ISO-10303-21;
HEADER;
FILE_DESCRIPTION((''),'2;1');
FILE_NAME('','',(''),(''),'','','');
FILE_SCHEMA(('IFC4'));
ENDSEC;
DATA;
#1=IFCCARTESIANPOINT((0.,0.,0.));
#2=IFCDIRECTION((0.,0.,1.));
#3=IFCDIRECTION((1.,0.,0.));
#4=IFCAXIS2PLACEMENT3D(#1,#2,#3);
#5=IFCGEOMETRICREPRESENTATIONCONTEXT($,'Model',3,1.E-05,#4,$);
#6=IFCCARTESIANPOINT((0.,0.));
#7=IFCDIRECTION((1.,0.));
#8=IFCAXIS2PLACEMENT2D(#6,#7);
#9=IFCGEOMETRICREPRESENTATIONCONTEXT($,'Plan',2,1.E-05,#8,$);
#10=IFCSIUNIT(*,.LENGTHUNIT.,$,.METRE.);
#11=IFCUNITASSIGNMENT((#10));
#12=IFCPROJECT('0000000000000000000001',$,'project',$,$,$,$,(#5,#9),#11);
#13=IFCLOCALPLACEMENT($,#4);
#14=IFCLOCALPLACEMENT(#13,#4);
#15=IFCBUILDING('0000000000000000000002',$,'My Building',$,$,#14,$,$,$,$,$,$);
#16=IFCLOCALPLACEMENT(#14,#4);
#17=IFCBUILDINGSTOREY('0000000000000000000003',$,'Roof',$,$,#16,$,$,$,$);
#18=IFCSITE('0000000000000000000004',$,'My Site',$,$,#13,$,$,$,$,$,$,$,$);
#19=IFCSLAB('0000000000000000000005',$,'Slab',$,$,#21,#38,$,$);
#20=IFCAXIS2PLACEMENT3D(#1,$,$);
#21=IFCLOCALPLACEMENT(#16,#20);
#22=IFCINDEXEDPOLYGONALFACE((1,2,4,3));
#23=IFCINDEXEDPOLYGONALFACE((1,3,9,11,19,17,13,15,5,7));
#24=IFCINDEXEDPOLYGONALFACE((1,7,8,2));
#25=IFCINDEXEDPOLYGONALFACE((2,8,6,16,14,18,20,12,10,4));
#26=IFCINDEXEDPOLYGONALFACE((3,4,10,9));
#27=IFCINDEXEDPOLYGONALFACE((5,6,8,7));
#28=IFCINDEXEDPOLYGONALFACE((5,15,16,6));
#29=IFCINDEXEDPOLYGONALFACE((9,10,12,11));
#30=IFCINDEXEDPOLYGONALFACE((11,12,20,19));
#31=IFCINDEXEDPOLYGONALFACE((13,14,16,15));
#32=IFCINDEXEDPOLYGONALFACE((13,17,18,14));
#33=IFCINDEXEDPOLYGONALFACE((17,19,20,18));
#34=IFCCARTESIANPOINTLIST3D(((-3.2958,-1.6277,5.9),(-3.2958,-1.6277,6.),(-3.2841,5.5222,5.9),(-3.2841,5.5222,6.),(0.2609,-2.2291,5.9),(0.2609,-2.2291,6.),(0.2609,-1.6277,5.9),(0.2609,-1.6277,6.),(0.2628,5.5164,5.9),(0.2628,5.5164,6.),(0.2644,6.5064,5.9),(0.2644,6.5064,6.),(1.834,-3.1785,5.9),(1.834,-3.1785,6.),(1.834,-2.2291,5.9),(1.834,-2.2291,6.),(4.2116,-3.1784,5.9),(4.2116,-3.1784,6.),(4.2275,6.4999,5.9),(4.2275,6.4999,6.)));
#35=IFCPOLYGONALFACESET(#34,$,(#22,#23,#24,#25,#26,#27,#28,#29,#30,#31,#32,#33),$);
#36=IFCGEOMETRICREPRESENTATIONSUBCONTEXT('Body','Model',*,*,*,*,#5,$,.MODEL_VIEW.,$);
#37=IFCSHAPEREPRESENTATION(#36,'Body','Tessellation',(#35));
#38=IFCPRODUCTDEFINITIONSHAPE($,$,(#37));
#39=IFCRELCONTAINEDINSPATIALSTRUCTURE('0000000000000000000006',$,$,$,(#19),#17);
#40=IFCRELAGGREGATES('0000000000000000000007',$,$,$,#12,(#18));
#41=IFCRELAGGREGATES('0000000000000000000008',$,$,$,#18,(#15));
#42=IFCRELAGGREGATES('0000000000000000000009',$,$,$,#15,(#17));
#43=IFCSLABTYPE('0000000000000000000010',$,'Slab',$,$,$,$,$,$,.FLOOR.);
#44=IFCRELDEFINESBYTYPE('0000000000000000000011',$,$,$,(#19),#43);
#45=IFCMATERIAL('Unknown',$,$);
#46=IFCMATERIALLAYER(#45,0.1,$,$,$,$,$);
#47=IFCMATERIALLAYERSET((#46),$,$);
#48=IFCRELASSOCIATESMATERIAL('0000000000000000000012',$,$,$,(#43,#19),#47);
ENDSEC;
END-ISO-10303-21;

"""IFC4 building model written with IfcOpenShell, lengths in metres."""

from ifc_helpers import new_model, si_unit, frame, origin_with_axes, origin_2d_with_axis, place, context, subcontext, project, spatial, indexed_curve, outline, extrude, material, layer, layer_set, layer_usage, type_object, element, save


model = new_model("IFC4")

# Units and contexts
model_context = context("Model", 3, precision=1e-05, world=origin_with_axes())
plan_context = context("Plan", 2, precision=1e-05, world=origin_2d_with_axis())
body_context = subcontext(model_context, "Body", "Model", "MODEL_VIEW")
ifc_project = project(units=[si_unit("LENGTHUNIT", "METRE")], contexts=[model_context, plan_context])

# Site, building, storey
site_placement = place(None, origin_with_axes())
site = spatial("IfcSite", under=ifc_project, at=site_placement, Name="My Site")
building_placement = place(site_placement, origin_with_axes())
building = spatial("IfcBuilding", under=site, at=building_placement, Name="My Building")
storey_placement = place(building_placement, origin_with_axes())
storey = spatial("IfcBuildingStorey", under=building, at=storey_placement, Name="Roof")

# Slab
ifc_material = material(Name="Unknown")
ifc_layer = layer(ifc_material, 0.1)
ifc_layer_set = layer_set([ifc_layer])
ifc_layer_usage = layer_usage(ifc_layer_set, "AXIS3", "POSITIVE", -0.1)
slab_type = type_object("IfcSlabType", Name="Slab", PredefinedType="FLOOR", material=ifc_layer_set)
slab_placement = place(storey_placement, frame((4.2116, -3.1784, 6.0), z_axis=(0.0, 0.0, 1.0), x_axis=(1.0, 0.0, 0.0)))
element("IfcSlab", 1, at=slab_placement, inside=storey, type_object=slab_type, material=ifc_layer_usage, Name="Slab", context=body_context, shape_type="SweptSolid", body=[
    extrude(outline(indexed_curve([(0.0, 0.0), (0.0159, 9.6783), (-3.9472, 9.6848), (-3.9489, 8.6948), (-7.4957, 8.7006), (-7.5075, 1.5506), (-3.9508, 1.5506), (-3.9508, 0.9493), (-2.3776, 0.9493), (-2.3776, -0.0001), (0.0, 0.0)])), frame((0.0, 0.0, -0.1), z_axis=(0.0, 0.0, 1.0), x_axis=(1.0, 0.0, 0.0)), (0.0, 0.0, 1.0), 0.1),
])

save(model, "model.ifc")
